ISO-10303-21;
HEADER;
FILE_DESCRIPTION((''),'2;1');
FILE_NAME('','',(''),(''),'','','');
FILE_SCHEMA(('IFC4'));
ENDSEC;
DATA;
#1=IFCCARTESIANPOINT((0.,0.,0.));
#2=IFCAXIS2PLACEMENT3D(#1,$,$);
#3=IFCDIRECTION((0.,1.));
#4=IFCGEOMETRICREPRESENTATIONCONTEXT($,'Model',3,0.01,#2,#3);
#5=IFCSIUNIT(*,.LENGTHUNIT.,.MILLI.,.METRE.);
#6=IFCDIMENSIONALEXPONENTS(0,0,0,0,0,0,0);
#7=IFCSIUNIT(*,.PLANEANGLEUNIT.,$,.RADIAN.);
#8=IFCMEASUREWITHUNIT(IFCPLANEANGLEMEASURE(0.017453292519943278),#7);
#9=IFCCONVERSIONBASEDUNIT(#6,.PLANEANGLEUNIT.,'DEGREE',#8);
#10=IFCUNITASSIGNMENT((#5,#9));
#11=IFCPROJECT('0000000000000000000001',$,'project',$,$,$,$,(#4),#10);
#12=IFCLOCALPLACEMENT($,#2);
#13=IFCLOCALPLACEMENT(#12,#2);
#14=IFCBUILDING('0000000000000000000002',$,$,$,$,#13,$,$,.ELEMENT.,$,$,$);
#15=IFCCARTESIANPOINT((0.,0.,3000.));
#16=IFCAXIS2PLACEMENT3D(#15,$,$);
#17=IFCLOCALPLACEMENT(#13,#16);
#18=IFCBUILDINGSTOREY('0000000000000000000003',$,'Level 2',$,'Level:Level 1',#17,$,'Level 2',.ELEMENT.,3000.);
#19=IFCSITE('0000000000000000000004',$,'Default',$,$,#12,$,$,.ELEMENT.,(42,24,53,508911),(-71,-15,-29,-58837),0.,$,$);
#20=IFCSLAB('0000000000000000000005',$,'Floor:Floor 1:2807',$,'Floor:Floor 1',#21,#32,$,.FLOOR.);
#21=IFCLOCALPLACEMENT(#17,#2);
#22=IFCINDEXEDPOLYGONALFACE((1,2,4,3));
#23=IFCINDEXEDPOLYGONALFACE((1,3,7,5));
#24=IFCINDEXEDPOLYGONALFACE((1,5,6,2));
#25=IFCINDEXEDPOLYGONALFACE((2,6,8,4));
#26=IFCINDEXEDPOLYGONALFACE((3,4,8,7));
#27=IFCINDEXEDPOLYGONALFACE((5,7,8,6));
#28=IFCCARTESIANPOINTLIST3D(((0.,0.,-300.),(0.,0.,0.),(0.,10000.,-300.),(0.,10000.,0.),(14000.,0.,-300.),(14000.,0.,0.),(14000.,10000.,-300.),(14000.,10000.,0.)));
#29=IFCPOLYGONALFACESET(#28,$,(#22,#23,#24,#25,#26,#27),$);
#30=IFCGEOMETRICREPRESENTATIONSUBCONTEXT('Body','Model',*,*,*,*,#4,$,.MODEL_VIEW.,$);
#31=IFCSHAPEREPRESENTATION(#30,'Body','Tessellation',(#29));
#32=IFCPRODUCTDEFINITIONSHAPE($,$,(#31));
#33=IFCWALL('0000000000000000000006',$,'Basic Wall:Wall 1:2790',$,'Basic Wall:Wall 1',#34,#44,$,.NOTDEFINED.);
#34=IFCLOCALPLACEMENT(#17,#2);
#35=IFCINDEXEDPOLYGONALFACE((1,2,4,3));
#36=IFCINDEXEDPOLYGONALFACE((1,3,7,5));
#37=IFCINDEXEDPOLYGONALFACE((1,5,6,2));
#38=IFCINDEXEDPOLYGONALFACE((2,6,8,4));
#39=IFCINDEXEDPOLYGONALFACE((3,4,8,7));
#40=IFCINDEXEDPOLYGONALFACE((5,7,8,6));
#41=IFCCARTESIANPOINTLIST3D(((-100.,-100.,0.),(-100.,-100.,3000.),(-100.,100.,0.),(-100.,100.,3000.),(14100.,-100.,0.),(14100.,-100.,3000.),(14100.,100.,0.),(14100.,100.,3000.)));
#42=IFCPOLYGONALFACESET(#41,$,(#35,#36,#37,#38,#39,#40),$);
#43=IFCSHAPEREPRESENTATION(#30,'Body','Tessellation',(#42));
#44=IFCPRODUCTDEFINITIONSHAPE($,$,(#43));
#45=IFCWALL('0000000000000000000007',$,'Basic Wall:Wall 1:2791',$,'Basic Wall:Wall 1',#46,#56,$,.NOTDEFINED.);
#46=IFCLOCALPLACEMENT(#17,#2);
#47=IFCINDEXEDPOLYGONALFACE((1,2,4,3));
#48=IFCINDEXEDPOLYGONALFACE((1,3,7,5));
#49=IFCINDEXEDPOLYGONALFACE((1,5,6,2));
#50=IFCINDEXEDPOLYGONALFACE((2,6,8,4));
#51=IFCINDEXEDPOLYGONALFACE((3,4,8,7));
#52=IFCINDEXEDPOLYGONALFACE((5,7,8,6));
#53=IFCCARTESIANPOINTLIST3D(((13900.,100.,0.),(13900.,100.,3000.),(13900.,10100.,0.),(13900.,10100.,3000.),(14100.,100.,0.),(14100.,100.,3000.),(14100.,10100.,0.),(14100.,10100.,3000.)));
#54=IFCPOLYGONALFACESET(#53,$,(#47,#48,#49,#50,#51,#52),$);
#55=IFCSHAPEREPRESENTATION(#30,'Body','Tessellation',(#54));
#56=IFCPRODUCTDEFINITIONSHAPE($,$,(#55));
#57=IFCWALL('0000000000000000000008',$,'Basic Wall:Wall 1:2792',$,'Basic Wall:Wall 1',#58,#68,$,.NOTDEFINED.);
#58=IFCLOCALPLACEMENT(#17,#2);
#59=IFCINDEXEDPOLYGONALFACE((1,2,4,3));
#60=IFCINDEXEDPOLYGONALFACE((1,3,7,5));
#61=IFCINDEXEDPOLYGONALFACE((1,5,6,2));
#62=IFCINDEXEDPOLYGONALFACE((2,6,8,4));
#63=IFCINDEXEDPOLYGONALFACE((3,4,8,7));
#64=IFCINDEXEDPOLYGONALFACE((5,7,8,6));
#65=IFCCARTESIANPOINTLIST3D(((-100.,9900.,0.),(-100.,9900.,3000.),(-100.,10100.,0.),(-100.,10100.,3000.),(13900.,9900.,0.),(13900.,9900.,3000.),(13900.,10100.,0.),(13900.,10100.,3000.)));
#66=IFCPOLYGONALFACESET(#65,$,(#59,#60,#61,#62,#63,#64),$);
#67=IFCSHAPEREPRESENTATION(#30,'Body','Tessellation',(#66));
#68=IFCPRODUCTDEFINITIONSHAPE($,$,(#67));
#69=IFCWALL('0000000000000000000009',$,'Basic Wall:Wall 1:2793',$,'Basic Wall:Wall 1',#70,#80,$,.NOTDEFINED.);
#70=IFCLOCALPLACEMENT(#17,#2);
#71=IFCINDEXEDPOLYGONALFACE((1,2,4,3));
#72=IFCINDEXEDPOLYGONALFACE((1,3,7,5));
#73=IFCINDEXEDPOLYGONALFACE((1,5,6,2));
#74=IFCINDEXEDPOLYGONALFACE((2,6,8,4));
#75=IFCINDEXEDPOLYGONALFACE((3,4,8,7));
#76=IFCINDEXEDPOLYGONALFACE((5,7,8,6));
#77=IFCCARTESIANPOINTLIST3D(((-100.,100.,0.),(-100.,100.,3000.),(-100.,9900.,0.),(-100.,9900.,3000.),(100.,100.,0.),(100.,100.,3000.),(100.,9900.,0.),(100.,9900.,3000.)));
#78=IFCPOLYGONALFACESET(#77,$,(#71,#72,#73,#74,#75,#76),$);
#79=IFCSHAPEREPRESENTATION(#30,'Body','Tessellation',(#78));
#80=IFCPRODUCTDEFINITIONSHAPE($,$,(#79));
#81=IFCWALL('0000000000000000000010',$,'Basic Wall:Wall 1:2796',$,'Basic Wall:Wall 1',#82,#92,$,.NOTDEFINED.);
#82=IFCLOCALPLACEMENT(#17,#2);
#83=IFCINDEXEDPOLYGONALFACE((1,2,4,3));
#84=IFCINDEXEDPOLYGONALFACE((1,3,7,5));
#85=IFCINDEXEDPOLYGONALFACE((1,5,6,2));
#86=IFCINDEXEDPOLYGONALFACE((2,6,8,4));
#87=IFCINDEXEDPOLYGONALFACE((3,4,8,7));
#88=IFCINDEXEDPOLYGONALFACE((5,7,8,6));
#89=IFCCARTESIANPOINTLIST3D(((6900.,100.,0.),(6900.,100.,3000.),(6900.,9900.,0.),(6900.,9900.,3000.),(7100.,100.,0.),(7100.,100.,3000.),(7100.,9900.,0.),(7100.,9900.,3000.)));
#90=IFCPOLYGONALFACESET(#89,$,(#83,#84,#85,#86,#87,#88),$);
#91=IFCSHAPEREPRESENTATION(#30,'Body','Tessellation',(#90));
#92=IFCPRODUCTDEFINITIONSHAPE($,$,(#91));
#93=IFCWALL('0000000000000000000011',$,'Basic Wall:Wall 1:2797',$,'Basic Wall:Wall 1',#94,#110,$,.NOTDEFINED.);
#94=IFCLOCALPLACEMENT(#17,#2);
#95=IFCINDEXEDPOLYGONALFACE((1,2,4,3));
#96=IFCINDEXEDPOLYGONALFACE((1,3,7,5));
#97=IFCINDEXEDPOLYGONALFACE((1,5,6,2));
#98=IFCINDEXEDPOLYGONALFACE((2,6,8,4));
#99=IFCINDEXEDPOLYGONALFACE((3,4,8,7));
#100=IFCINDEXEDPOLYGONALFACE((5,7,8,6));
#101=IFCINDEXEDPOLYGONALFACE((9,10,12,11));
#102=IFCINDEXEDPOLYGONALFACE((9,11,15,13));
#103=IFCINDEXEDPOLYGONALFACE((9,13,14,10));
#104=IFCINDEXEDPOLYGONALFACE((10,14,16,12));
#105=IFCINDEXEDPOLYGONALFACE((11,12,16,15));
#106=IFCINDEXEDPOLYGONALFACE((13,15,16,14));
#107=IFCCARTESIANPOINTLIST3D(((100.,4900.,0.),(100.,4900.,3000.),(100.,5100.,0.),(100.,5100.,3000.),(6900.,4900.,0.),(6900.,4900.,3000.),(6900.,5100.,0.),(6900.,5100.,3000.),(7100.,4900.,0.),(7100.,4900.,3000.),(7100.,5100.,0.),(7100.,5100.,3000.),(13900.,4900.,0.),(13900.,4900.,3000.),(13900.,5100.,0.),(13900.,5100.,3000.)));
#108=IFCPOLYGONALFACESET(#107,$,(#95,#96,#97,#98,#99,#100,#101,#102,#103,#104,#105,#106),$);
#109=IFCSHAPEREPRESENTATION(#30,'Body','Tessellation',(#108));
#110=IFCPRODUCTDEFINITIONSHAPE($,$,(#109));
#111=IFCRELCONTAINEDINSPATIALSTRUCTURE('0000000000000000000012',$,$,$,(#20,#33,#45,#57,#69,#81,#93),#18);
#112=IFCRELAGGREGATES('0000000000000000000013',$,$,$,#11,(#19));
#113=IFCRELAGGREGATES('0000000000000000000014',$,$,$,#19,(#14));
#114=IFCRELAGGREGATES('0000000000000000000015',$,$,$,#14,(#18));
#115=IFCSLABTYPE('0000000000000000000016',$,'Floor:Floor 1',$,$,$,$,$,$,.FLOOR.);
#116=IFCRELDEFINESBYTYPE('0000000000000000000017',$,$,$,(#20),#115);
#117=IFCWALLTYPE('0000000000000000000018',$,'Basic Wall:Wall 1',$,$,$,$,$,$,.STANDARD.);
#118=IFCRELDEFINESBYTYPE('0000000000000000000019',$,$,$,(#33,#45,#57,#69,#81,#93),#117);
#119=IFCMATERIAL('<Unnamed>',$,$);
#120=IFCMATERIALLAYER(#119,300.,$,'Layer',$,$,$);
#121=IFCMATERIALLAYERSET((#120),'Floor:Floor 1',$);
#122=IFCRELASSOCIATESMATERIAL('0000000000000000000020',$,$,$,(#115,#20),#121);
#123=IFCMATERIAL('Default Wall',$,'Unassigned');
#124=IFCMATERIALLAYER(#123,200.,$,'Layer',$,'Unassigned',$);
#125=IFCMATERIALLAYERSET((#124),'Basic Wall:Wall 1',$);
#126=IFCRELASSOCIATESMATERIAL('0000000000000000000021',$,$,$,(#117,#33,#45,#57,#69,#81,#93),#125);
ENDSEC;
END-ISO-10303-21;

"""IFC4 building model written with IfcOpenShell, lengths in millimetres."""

from ifc_helpers import new_model, entity, si_unit, converted_unit, direction, frame, frame_2d, origin, origin_2d_with_axis, place, context, subcontext, project, spatial, rectangle, extrude, material, layer, layer_set, layer_usage, type_object, element, save


model = new_model("IFC4")

# Units and contexts
model_context = context("Model", 3, precision=0.01, world=origin(), true_north=direction((0.0, 1.0)))
body_context = subcontext(model_context, "Body", "Model", "MODEL_VIEW")
ifc_project = project(units=[si_unit("LENGTHUNIT", "METRE", prefix="MILLI"), converted_unit("PLANEANGLEUNIT", "DEGREE", entity("IfcPlaneAngleMeasure", 0.017453292519943278), si_unit("PLANEANGLEUNIT", "RADIAN"), dimensions=[0, 0, 0, 0, 0, 0, 0])], contexts=[model_context])

# Site, building, storey
site_placement = place(None, origin())
site = spatial("IfcSite", under=ifc_project, at=site_placement, Name="Default", CompositionType="ELEMENT", RefLatitude=(42, 24, 53, 508911), RefLongitude=(-71, -15, -29, -58837), RefElevation=0.0)
building_placement = place(site_placement, origin())
building = spatial("IfcBuilding", under=site, at=building_placement, CompositionType="ELEMENT")
storey_placement = place(building_placement, frame((0.0, 0.0, 3000.0)))
storey = spatial("IfcBuildingStorey", under=building, at=storey_placement, Name="Level 2", ObjectType="Level:Level 1", LongName="Level 2", CompositionType="ELEMENT", Elevation=3000.0)

# Slab
ifc_material_1 = material(Name="<Unnamed>")
ifc_layer_1 = layer(ifc_material_1, 300.0, Name="Layer")
ifc_layer_set_1 = layer_set([ifc_layer_1], Name="Floor:Floor 1")
ifc_layer_usage_1 = layer_usage(ifc_layer_set_1, "AXIS3", "POSITIVE", 0.0)
slab_type = type_object("IfcSlabType", Name="Floor:Floor 1", PredefinedType="FLOOR", material=ifc_layer_set_1)
slab_placement = place(storey_placement, origin())
element("IfcSlab", 1, at=slab_placement, inside=storey, type_object=slab_type, material=ifc_layer_usage_1, Name="Floor:Floor 1:2807", ObjectType="Floor:Floor 1", PredefinedType="FLOOR", context=body_context, shape_type="SweptSolid", body=[
    extrude(rectangle(XDim=10000.0, YDim=14000.0, at=origin_2d_with_axis()), frame((7000.0, 5000.0, 0.0), z_axis=(0.0, 0.0, -1.0), x_axis=(0.0, 1.0, 0.0)), (0.0, 0.0, 1.0), 300.0),
])

# Walls
ifc_material_2 = material(Name="Default Wall", Category="Unassigned")
ifc_layer_2 = layer(ifc_material_2, 200.0, Name="Layer", Category="Unassigned")
ifc_layer_set_2 = layer_set([ifc_layer_2], Name="Basic Wall:Wall 1")
ifc_layer_usage_2 = layer_usage(ifc_layer_set_2, "AXIS2", "NEGATIVE", 100.0)
wall_type = type_object("IfcWallType", Name="Basic Wall:Wall 1", PredefinedType="STANDARD", material=ifc_layer_set_2)
wall_1_placement = place(storey_placement, frame((-100.0, 0.0, 0.0)))
element("IfcWall", 2, at=wall_1_placement, inside=storey, type_object=wall_type, material=ifc_layer_usage_2, Name="Basic Wall:Wall 1:2790", ObjectType="Basic Wall:Wall 1", PredefinedType="NOTDEFINED", context=body_context, shape_type="SweptSolid", body=[
    extrude(rectangle(XDim=14200.0, YDim=200.0, at=frame_2d((7100.0, 0.0), x_axis=(-1.0, 0.0))), origin(), (0.0, 0.0, 1.0), 3000.0),
])
ifc_layer_usage_3 = layer_usage(ifc_layer_set_2, "AXIS2", "NEGATIVE", 100.0)
wall_2_placement = place(storey_placement, frame((14000.0, 100.0, 0.0), z_axis=(0.0, 0.0, 1.0), x_axis=(0.0, 1.0, 0.0)))
element("IfcWall", 3, at=wall_2_placement, inside=storey, type_object=wall_type, material=ifc_layer_usage_3, Name="Basic Wall:Wall 1:2791", ObjectType="Basic Wall:Wall 1", PredefinedType="NOTDEFINED", context=body_context, shape_type="SweptSolid", body=[
    extrude(rectangle(XDim=10000.0, YDim=200.0, at=frame_2d((5000.0, 0.0), x_axis=(-1.0, 0.0))), origin(), (0.0, 0.0, 1.0), 3000.0),
])
ifc_layer_usage_4 = layer_usage(ifc_layer_set_2, "AXIS2", "NEGATIVE", 100.0)
wall_3_placement = place(storey_placement, frame((13900.0, 10000.0, 0.0), z_axis=(0.0, 0.0, 1.0), x_axis=(-1.0, 0.0, 0.0)))
element("IfcWall", 4, at=wall_3_placement, inside=storey, type_object=wall_type, material=ifc_layer_usage_4, Name="Basic Wall:Wall 1:2792", ObjectType="Basic Wall:Wall 1", PredefinedType="NOTDEFINED", context=body_context, shape_type="SweptSolid", body=[
    extrude(rectangle(XDim=14000.0, YDim=200.0, at=frame_2d((7000.0, 0.0), x_axis=(-1.0, 0.0))), origin(), (0.0, 0.0, 1.0), 3000.0),
])
ifc_layer_usage_5 = layer_usage(ifc_layer_set_2, "AXIS2", "NEGATIVE", 100.0)
wall_4_placement = place(storey_placement, frame((0.0, 9900.0, 0.0), z_axis=(0.0, 0.0, 1.0), x_axis=(0.0, -1.0, 0.0)))
element("IfcWall", 5, at=wall_4_placement, inside=storey, type_object=wall_type, material=ifc_layer_usage_5, Name="Basic Wall:Wall 1:2793", ObjectType="Basic Wall:Wall 1", PredefinedType="NOTDEFINED", context=body_context, shape_type="SweptSolid", body=[
    extrude(rectangle(XDim=9800.0, YDim=200.0, at=frame_2d((4900.0, 0.0), x_axis=(-1.0, 0.0))), origin(), (0.0, 0.0, 1.0), 3000.0),
])
ifc_layer_usage_6 = layer_usage(ifc_layer_set_2, "AXIS2", "NEGATIVE", 100.0)
wall_5_placement = place(storey_placement, frame((7000.0, 100.0, 0.0), z_axis=(0.0, 0.0, 1.0), x_axis=(0.0, 1.0, 0.0)))
element("IfcWall", 6, at=wall_5_placement, inside=storey, type_object=wall_type, material=ifc_layer_usage_6, Name="Basic Wall:Wall 1:2796", ObjectType="Basic Wall:Wall 1", PredefinedType="NOTDEFINED", context=body_context, shape_type="SweptSolid", body=[
    extrude(rectangle(XDim=9800.0, YDim=200.0, at=frame_2d((4900.0, 0.0), x_axis=(-1.0, 0.0))), origin(), (0.0, 0.0, 1.0), 3000.0),
])

# Wall, opening
ifc_layer_usage_7 = layer_usage(ifc_layer_set_2, "AXIS2", "NEGATIVE", 100.0)
wall_6_placement = place(storey_placement, frame((100.0, 5000.0, 0.0)))
wall_6 = element("IfcWall", 7, at=wall_6_placement, inside=storey, type_object=wall_type, material=ifc_layer_usage_7, Name="Basic Wall:Wall 1:2797", ObjectType="Basic Wall:Wall 1", PredefinedType="NOTDEFINED", context=body_context, shape_type="SweptSolid", body=[
    extrude(rectangle(XDim=13800.0, YDim=200.0, at=frame_2d((6900.0, 0.0), x_axis=(-1.0, 0.0))), origin(), (0.0, 0.0, 1.0), 3000.0),
])
opening_placement = place(storey_placement, frame((100.0, 5000.0, 0.0)))
element("IfcOpeningElement", 8, at=opening_placement, cuts=wall_6, PredefinedType="OPENING", context=body_context, shape_type="SweptSolid", body=[
    extrude(rectangle(XDim=3000.0, YDim=200.0, at=origin_2d_with_axis()), frame((6800.0, 0.0, 1500.0), z_axis=(1.0, 0.0, 0.0), x_axis=(0.0, 0.0, -1.0)), (0.0, 0.0, 1.0), 200.0),
])

save(model, "model.ifc")
